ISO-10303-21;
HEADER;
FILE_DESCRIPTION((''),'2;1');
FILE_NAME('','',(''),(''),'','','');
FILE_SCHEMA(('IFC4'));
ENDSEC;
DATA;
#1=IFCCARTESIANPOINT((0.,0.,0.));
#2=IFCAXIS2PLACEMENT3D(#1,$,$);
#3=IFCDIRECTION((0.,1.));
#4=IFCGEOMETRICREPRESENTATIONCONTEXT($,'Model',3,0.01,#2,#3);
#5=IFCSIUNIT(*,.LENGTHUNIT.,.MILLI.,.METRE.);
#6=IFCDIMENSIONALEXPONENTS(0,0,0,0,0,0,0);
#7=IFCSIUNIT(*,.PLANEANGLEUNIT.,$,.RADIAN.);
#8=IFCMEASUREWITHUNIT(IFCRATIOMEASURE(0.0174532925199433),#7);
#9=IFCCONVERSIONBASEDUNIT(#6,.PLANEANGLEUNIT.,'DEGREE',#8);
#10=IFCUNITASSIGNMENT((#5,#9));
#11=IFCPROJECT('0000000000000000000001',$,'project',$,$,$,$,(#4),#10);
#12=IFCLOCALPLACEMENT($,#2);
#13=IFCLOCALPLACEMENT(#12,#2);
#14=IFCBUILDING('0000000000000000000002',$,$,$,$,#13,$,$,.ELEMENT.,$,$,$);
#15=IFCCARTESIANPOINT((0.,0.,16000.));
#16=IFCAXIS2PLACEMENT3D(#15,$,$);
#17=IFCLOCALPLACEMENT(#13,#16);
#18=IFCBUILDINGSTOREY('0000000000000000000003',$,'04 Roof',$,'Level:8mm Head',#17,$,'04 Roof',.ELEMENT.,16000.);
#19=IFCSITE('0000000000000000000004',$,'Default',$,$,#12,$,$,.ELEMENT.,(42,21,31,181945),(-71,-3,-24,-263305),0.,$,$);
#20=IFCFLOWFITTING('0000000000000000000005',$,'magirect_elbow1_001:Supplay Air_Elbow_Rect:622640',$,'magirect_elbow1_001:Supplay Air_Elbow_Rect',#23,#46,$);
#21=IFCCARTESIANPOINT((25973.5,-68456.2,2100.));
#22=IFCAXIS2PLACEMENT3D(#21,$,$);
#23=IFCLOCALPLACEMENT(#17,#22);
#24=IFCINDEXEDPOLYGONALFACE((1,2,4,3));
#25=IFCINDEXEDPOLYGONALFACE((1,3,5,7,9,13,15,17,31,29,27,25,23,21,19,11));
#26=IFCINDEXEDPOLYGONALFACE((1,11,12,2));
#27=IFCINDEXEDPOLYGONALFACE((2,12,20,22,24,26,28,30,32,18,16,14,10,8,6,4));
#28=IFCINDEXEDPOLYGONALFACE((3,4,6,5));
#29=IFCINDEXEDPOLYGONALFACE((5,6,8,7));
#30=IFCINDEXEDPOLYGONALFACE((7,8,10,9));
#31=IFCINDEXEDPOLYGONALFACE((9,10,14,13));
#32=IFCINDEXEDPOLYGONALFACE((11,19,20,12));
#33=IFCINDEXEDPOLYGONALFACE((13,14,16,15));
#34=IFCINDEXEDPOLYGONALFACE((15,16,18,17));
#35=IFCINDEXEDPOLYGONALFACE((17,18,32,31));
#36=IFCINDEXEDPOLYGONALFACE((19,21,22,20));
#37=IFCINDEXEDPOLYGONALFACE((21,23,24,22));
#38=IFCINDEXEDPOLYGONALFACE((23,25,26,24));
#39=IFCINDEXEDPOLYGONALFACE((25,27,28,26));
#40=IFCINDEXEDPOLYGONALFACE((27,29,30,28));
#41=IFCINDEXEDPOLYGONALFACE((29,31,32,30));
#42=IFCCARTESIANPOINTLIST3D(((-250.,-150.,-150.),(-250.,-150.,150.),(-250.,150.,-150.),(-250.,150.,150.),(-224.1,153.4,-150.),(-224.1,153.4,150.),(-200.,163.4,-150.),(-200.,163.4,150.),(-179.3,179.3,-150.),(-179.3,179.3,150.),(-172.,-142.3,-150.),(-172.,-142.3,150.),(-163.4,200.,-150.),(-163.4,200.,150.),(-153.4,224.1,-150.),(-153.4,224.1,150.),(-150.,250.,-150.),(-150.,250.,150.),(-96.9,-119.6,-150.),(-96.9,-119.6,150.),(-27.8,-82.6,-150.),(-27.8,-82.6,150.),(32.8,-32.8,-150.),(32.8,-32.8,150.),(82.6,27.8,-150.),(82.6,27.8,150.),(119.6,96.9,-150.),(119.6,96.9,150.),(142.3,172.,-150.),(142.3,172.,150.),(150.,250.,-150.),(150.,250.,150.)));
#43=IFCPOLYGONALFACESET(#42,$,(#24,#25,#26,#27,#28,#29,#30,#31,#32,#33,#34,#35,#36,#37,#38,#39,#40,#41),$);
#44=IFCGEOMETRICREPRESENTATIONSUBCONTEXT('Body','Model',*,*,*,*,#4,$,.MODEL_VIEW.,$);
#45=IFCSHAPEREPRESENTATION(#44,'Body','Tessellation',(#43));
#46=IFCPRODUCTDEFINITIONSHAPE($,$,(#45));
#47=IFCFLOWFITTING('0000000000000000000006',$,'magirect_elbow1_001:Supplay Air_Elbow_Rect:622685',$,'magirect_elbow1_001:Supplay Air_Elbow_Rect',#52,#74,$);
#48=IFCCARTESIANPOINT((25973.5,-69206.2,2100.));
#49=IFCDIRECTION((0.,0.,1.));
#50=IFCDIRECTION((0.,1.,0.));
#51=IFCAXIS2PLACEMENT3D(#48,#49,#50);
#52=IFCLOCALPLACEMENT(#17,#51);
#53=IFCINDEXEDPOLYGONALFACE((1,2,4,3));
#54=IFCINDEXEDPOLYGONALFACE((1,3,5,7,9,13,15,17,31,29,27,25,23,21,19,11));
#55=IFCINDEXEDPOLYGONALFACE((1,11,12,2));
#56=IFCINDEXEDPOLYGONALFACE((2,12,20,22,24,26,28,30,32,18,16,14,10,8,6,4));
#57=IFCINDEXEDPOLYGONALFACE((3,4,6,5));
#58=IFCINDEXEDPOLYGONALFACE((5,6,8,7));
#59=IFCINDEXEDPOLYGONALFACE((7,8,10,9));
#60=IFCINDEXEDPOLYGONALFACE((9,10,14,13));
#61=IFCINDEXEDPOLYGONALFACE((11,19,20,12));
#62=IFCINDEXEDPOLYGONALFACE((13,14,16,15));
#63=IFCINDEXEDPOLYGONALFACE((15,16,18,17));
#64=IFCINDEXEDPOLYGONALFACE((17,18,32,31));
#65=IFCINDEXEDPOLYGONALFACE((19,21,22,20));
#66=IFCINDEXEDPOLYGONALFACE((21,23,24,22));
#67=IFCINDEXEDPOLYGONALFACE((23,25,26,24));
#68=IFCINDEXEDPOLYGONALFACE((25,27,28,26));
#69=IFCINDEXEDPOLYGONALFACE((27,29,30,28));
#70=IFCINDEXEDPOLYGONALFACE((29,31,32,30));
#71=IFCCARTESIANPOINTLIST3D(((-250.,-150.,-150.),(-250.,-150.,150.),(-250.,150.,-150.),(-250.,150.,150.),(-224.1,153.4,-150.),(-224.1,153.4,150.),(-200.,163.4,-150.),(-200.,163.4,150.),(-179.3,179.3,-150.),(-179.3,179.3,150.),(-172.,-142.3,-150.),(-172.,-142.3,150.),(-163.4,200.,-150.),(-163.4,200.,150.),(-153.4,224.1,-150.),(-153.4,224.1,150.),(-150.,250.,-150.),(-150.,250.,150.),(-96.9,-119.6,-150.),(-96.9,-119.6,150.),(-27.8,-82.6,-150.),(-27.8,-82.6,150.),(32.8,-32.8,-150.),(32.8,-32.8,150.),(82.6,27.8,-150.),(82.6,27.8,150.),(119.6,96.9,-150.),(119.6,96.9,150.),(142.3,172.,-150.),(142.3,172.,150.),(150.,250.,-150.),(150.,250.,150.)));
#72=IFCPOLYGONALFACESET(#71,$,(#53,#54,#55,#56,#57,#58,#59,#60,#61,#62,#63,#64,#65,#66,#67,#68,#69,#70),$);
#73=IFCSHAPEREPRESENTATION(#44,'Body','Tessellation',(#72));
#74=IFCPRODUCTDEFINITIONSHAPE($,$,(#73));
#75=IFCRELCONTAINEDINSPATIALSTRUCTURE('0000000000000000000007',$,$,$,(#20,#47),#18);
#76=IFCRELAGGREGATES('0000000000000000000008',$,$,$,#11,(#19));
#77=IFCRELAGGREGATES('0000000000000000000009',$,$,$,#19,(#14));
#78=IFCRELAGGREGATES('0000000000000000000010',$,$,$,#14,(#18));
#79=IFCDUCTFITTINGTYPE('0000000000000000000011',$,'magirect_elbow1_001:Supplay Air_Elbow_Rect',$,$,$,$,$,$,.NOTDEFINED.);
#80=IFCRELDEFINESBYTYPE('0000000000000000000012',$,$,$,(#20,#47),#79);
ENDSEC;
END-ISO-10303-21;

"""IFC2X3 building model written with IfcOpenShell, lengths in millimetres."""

from ifc_helpers import new_model, entity, si_unit, converted_unit, direction, frame, frame_2d, origin, place, context, subcontext, project, spatial, polyline, circle_curve, parameter, trimmed, segment, composite_curve, outline, extrude, source, transform, mapped, type_object, type_shapes, element, save


model = new_model("IFC2X3")

# Units and contexts
model_context = context("Model", 3, precision=0.01, world=origin(), true_north=direction((0.0, 1.0)))
body_context = subcontext(model_context, "Body", "Model", "MODEL_VIEW")
ifc_project = project(units=[si_unit("LENGTHUNIT", "METRE", prefix="MILLI"), converted_unit("PLANEANGLEUNIT", "DEGREE", entity("IfcRatioMeasure", 0.0174532925199433), si_unit("PLANEANGLEUNIT", "RADIAN"), dimensions=[0, 0, 0, 0, 0, 0, 0])], contexts=[model_context])

# Site, building, storey
site_placement = place(None, origin())
site = spatial("IfcSite", under=ifc_project, at=site_placement, Name="Default", CompositionType="ELEMENT", RefLatitude=(42, 21, 31, 181945), RefLongitude=(-71, -3, -24, -263305), RefElevation=0.0)
building_placement = place(site_placement, origin())
building = spatial("IfcBuilding", under=site, at=building_placement, CompositionType="ELEMENT")
storey_placement = place(building_placement, frame((0.0, 0.0, 16000.0)))
storey = spatial("IfcBuildingStorey", under=building, at=storey_placement, Name="04 Roof", ObjectType="Level:8mm Head", LongName="04 Roof", CompositionType="ELEMENT", Elevation=16000.0)

# Flow fittings
duct_fitting_type_1 = type_object("IfcDuctFittingType", Name="magirect_elbow1_001:Supplay Air_Elbow_Rect", PredefinedType="NOTDEFINED")
shared_shape_1 = source(origin(), body_context, "Body", "SweptSolid", [
    extrude(outline(composite_curve([segment(polyline([(-275.0, -125.0), (25.0, -125.0)]), True, "CONTINUOUS"), segment(trimmed(circle_curve(frame_2d((125.0, -125.0), x_axis=(0.0, 1.0)), 100.0), [parameter(0.0)], [parameter(90.0)], True, "PARAMETER"), False, "CONTINUOUS"), segment(polyline([(125.0, -25.0), (125.0, 275.0)]), True, "CONTINUOUS"), segment(trimmed(circle_curve(frame_2d((125.0, -125.0), x_axis=(0.0, 1.0)), 400.0), [parameter(0.0)], [parameter(90.0)], True, "PARAMETER"), True, "CONTINUOUS")], self_intersect=False)), frame((-125.0, 125.0, -150.0), z_axis=(0.0, 0.0, 1.0), x_axis=(-1.0, 0.0, 0.0)), (0.0, 0.0, 1.0), 300.0),
])
type_shapes(duct_fitting_type_1, [shared_shape_1])
flow_fitting_1_placement = place(storey_placement, frame((25973.5, -68456.2, 2100.0)))
element("IfcFlowFitting", 1, at=flow_fitting_1_placement, inside=storey, type_object=duct_fitting_type_1, Name="magirect_elbow1_001:Supplay Air_Elbow_Rect:622640", ObjectType="magirect_elbow1_001:Supplay Air_Elbow_Rect", context=body_context, shape_type="MappedRepresentation", body=[
    mapped(shared_shape_1, transform((0.0, 0.0, 0.0), scale=1.0)),
])
flow_fitting_2_placement = place(storey_placement, frame((25973.5, -69206.2, 2100.0), z_axis=(0.0, 0.0, 1.0), x_axis=(0.0, 1.0, 0.0)))
element("IfcFlowFitting", 2, at=flow_fitting_2_placement, inside=storey, type_object=duct_fitting_type_1, Name="magirect_elbow1_001:Supplay Air_Elbow_Rect:622685", ObjectType="magirect_elbow1_001:Supplay Air_Elbow_Rect", context=body_context, shape_type="MappedRepresentation", body=[
    mapped(shared_shape_1, transform((0.0, 0.0, 0.0), scale=1.0)),
])

save(model, "model.ifc")
